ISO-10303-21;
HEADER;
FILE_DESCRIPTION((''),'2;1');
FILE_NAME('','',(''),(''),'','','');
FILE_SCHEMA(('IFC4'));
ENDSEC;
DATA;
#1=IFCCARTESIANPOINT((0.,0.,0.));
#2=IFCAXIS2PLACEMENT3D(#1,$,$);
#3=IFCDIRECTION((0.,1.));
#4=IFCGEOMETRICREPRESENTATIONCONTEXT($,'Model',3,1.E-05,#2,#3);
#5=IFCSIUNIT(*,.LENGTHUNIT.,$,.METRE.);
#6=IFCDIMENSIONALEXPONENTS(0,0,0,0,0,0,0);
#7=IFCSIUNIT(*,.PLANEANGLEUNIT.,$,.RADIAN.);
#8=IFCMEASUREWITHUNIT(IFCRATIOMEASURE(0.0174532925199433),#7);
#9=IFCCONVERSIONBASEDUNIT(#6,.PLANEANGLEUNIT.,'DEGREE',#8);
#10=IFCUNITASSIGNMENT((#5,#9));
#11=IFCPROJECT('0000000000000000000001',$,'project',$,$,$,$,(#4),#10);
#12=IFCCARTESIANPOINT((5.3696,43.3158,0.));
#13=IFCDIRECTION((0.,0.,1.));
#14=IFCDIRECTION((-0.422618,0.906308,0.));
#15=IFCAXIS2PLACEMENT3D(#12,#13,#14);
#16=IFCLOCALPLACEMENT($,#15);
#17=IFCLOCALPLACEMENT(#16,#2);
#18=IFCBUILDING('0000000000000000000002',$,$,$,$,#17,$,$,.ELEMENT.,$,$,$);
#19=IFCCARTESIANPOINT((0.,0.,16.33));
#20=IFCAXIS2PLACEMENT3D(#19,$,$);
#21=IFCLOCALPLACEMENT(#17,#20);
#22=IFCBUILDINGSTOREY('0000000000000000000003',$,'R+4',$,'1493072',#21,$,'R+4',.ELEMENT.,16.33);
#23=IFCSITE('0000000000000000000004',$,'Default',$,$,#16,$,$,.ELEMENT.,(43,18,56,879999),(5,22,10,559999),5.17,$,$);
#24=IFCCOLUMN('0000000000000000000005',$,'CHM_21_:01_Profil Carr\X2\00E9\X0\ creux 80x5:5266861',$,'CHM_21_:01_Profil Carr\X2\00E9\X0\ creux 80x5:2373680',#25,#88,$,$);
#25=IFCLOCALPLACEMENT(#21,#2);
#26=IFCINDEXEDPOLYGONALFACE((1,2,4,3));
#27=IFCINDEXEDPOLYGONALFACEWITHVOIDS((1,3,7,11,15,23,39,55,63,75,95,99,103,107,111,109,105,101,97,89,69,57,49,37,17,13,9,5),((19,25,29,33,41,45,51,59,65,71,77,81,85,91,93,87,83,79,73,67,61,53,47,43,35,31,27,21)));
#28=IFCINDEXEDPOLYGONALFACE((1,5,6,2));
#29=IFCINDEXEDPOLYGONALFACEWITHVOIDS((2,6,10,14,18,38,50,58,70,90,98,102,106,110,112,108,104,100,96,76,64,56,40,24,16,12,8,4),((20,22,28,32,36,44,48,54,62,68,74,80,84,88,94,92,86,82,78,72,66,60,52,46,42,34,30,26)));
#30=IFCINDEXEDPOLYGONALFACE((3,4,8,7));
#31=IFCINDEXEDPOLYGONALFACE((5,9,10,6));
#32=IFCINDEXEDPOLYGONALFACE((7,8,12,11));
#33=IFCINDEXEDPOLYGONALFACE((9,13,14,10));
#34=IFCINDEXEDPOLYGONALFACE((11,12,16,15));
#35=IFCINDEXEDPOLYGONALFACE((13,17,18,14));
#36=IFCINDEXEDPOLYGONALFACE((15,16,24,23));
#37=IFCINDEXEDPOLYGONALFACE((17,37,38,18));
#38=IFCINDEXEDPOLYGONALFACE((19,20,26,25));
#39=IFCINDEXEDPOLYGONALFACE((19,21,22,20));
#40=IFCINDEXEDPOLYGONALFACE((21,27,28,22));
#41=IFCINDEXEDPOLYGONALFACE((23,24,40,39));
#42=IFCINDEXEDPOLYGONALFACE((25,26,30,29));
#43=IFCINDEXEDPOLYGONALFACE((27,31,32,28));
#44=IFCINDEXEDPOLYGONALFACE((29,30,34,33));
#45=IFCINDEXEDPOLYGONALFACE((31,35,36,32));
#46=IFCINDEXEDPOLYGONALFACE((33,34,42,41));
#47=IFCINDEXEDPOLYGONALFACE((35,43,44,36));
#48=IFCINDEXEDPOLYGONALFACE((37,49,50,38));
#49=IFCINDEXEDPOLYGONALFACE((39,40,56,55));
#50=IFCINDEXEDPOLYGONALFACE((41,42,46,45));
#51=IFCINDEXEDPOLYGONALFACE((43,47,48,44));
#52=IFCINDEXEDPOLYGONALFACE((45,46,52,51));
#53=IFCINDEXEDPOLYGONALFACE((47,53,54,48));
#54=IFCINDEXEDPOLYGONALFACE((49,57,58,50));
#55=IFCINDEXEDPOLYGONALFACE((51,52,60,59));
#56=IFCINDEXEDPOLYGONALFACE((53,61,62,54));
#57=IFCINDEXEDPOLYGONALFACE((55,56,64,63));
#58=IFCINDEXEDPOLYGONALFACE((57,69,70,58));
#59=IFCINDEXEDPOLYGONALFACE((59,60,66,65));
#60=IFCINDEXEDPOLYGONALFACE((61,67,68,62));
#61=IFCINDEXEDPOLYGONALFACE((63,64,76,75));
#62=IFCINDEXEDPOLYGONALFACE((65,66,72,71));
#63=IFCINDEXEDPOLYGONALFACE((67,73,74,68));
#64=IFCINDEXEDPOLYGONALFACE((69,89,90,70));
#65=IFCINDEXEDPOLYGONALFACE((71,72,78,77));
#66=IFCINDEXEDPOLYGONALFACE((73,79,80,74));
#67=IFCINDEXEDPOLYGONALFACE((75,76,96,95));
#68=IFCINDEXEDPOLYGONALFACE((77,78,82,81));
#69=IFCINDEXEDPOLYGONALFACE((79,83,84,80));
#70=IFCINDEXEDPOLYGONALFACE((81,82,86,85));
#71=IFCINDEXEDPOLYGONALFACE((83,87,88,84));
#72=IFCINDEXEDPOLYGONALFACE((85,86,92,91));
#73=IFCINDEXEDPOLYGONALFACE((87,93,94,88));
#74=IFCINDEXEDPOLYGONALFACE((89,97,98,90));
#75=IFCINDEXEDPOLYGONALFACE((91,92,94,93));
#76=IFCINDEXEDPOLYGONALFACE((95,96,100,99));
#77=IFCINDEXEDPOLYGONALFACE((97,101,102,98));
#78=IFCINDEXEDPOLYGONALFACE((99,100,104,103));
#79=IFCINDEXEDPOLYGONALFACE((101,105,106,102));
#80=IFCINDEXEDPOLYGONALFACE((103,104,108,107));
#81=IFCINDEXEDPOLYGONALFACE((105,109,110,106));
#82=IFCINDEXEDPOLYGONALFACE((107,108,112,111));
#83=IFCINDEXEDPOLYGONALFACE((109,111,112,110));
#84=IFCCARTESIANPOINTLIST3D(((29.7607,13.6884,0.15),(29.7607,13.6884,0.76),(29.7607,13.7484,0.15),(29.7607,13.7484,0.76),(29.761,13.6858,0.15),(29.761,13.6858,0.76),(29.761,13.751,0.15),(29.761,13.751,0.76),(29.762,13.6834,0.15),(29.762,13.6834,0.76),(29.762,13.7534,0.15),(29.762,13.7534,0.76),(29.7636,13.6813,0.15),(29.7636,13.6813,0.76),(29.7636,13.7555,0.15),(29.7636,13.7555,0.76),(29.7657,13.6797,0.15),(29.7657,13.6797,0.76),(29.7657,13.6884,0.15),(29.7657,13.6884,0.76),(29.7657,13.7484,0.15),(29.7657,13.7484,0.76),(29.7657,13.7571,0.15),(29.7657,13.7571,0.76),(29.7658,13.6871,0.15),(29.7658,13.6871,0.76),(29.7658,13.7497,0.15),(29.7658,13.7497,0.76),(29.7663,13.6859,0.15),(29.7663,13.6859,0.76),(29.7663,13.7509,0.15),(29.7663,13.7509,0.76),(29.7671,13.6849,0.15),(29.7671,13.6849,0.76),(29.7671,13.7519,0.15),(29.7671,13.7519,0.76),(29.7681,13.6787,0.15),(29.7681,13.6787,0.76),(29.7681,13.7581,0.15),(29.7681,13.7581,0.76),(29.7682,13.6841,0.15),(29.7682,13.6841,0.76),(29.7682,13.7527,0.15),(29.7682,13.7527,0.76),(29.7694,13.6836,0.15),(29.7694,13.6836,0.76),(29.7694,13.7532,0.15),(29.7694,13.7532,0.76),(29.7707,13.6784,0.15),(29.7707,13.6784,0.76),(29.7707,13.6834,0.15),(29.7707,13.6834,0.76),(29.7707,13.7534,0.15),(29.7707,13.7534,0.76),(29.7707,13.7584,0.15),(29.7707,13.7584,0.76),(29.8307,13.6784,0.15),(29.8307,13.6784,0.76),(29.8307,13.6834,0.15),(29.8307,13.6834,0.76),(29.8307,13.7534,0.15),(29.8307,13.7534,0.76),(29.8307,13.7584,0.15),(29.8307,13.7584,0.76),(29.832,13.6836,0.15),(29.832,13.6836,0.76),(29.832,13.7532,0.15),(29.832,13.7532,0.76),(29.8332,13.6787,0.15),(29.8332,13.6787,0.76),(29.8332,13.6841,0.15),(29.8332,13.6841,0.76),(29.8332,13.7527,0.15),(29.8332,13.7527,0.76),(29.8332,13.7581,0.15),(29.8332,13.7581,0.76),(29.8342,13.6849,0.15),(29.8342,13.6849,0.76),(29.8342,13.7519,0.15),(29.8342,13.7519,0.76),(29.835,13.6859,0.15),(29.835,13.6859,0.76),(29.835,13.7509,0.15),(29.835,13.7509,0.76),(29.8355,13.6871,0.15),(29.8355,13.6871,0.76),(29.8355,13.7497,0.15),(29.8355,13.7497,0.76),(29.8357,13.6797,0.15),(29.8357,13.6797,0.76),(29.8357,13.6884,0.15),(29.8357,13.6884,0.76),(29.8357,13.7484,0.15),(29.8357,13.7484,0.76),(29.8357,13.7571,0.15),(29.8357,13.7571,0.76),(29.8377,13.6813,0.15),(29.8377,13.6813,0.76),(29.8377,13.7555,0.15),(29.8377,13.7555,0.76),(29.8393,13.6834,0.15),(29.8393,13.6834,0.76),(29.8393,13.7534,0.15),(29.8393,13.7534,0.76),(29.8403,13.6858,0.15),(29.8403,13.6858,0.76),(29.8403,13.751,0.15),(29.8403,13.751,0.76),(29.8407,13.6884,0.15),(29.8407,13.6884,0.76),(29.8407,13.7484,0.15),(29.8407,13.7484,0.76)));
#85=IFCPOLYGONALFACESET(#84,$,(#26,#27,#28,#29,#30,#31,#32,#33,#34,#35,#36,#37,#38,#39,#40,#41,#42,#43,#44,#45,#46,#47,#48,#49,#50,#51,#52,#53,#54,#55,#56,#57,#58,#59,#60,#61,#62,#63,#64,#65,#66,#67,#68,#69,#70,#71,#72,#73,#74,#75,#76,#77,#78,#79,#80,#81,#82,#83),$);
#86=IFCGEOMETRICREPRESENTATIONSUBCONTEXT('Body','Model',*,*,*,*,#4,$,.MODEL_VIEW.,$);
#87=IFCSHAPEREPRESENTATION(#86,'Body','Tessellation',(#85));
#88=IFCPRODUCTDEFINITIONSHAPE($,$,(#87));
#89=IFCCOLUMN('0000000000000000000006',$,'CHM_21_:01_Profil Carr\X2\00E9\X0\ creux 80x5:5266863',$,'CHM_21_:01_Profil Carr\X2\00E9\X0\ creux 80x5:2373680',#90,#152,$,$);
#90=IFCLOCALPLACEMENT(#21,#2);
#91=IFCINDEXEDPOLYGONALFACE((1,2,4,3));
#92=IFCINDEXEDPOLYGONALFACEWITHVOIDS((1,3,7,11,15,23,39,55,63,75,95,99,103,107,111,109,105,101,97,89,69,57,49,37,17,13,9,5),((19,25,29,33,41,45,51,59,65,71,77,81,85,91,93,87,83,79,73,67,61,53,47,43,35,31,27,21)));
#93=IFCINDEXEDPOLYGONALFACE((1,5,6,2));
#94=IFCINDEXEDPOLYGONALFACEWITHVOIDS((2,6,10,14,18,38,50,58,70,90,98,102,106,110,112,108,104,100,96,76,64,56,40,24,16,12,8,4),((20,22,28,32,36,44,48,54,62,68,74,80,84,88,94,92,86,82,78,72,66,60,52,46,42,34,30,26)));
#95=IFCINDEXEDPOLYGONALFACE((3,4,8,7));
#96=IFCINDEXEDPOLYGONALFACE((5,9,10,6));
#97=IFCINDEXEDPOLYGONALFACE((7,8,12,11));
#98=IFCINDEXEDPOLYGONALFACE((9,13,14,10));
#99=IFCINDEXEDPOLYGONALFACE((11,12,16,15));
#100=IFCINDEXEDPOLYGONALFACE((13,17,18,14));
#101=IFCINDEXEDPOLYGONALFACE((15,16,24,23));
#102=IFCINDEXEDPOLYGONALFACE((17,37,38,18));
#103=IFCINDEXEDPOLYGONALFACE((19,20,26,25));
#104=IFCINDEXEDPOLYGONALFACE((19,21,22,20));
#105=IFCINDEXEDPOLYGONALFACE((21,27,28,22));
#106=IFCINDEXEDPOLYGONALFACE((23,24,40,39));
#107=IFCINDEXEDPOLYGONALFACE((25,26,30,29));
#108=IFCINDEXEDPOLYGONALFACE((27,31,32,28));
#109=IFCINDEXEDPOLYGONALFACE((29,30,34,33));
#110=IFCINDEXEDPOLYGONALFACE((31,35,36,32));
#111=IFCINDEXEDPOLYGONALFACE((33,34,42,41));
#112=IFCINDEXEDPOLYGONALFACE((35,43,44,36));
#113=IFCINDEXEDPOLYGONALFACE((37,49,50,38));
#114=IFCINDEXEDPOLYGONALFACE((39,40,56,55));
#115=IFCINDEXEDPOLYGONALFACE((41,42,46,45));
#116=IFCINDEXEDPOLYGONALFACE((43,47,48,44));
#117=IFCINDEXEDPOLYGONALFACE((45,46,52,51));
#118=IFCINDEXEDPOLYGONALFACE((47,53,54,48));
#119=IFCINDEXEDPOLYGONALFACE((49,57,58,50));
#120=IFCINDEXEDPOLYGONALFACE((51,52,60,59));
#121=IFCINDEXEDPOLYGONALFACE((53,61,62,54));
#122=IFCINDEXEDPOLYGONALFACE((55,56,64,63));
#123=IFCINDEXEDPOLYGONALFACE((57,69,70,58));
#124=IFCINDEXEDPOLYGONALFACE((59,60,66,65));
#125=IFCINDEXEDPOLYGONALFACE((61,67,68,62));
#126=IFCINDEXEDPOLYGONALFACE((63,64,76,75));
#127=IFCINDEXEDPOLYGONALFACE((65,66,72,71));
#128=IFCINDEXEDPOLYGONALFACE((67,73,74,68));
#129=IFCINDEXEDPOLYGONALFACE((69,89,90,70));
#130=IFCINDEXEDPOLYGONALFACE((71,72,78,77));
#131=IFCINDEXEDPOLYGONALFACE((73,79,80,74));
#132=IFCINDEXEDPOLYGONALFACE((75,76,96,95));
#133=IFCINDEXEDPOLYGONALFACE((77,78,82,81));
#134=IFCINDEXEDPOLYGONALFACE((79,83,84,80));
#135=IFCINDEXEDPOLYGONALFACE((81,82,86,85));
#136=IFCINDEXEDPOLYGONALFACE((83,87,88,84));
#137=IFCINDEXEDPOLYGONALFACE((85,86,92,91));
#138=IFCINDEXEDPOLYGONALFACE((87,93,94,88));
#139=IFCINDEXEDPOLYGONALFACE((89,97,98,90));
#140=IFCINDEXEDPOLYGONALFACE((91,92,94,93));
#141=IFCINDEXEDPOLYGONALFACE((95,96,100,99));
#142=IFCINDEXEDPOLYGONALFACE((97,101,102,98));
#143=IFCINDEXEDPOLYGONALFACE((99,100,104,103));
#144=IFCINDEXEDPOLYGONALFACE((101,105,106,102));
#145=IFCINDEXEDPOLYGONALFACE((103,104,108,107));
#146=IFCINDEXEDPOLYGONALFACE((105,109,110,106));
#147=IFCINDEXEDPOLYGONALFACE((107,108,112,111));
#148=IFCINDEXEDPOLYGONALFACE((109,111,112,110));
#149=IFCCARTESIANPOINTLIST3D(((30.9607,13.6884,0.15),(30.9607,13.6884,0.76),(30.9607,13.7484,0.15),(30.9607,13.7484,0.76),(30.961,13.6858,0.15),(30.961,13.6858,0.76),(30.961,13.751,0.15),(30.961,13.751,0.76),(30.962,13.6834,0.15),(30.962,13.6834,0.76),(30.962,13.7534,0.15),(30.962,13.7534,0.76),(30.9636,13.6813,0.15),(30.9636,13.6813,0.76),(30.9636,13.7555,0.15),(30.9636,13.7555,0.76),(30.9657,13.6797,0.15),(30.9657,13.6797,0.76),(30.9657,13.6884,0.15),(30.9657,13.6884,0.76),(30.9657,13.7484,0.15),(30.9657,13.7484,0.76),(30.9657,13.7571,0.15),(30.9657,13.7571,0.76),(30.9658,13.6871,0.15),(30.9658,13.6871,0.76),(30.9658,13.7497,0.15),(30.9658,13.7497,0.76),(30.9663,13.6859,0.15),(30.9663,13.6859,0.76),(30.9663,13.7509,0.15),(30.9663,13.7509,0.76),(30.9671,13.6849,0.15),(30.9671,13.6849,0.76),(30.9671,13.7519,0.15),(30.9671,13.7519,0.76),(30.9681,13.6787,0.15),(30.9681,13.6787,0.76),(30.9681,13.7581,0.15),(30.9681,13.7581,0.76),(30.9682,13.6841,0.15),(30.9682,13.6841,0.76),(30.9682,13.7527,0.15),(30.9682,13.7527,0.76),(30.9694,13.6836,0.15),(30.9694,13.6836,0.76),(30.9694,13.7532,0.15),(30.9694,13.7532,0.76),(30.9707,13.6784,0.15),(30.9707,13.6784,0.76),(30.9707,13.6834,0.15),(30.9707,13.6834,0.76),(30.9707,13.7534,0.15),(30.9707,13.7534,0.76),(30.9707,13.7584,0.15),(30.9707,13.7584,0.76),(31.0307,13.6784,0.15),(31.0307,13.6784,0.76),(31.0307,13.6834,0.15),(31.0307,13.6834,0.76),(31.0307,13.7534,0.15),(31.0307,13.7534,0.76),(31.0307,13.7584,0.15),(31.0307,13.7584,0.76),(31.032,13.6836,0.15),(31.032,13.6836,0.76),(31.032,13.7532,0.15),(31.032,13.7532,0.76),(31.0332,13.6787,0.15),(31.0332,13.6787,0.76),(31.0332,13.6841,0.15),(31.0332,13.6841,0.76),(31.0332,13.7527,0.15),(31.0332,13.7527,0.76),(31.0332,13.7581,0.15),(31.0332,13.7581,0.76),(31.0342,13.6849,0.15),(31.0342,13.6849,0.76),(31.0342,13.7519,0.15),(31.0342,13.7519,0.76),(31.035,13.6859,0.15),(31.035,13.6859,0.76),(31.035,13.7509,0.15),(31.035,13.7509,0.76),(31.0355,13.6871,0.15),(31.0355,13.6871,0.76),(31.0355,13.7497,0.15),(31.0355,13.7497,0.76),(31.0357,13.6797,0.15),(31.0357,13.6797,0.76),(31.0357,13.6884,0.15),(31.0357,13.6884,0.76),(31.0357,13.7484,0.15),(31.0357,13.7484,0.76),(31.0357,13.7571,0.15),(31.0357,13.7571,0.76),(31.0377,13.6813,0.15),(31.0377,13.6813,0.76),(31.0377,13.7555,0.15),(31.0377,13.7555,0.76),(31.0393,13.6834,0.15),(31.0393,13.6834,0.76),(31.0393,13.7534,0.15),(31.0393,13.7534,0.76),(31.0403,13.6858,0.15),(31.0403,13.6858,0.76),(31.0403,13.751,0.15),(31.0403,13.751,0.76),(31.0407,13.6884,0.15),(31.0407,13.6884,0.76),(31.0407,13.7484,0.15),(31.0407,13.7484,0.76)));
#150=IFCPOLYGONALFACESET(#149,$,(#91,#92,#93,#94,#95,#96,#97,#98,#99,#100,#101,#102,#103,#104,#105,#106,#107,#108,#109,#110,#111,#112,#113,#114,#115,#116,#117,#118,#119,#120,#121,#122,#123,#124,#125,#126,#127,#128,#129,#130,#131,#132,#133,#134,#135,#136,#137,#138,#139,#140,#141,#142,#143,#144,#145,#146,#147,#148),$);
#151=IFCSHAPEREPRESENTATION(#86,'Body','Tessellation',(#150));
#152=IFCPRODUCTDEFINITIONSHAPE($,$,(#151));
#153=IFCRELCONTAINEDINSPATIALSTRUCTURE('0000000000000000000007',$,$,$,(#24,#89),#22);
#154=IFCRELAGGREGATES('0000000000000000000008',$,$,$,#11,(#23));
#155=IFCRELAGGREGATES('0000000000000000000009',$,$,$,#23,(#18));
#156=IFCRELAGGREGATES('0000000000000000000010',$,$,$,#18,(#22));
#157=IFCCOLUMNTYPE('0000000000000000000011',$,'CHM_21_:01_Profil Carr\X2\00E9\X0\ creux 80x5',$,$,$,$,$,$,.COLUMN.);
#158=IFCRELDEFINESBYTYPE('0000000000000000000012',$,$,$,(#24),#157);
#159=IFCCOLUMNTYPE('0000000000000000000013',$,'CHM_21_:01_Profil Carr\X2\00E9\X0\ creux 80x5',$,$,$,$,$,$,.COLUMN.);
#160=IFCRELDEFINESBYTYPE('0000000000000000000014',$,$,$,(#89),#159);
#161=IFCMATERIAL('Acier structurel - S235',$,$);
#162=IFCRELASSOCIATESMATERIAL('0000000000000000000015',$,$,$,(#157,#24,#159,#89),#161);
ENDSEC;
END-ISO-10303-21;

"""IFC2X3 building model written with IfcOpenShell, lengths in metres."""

from ifc_helpers import new_model, entity, si_unit, converted_unit, direction, frame, frame_2d, origin, place, context, subcontext, project, spatial, polyline, circle_curve, parameter, trimmed, segment, composite_curve, outline, extrude, source, transform, mapped, material, type_object, type_shapes, element, save


model = new_model("IFC2X3")

# Units and contexts
model_context = context("Model", 3, precision=1e-05, world=origin(), true_north=direction((0.0, 1.0)))
body_context = subcontext(model_context, "Body", "Model", "MODEL_VIEW")
ifc_project = project(units=[si_unit("LENGTHUNIT", "METRE"), converted_unit("PLANEANGLEUNIT", "DEGREE", entity("IfcRatioMeasure", 0.0174532925199433), si_unit("PLANEANGLEUNIT", "RADIAN"), dimensions=[0, 0, 0, 0, 0, 0, 0])], contexts=[model_context])

# Site, building, storey
site_placement = place(None, frame((5.3696, 43.3158, 0.0), z_axis=(0.0, 0.0, 1.0), x_axis=(-0.422618, 0.906308, 0.0)))
site = spatial("IfcSite", under=ifc_project, at=site_placement, Name="Default", CompositionType="ELEMENT", RefLatitude=(43, 18, 56, 879999), RefLongitude=(5, 22, 10, 559999), RefElevation=5.17)
building_placement = place(site_placement, origin())
building = spatial("IfcBuilding", under=site, at=building_placement, CompositionType="ELEMENT")
storey_placement = place(building_placement, frame((0.0, 0.0, 16.33)))
storey = spatial("IfcBuildingStorey", under=building, at=storey_placement, Name="R+4", ObjectType="1493072", LongName="R+4", CompositionType="ELEMENT", Elevation=16.33)

# Columns
ifc_material_1 = material(Name="Acier structurel - S235")
column_type_1 = type_object("IfcColumnType", Name="CHM_21_:01_Profil Carré creux 80x5", PredefinedType="COLUMN", material=ifc_material_1)
shared_shape_1 = source(origin(), body_context, "Body", "SweptSolid", [
    extrude(outline(composite_curve([segment(polyline([(-0.03, -0.04), (0.03, -0.04)]), True, "CONTINUOUS"), segment(trimmed(circle_curve(frame_2d((0.03, -0.03), x_axis=(-1.0, 0.0)), 0.01), [parameter(90.0)], [parameter(180.0)], True, "PARAMETER"), True, "CONTINUOUS"), segment(polyline([(0.04, -0.03), (0.04, 0.03)]), True, "CONTINUOUS"), segment(trimmed(circle_curve(frame_2d((0.03, 0.03), x_axis=(-1.0, 0.0)), 0.01), [parameter(180.0)], [parameter(270.0)], True, "PARAMETER"), True, "CONTINUOUS"), segment(polyline([(0.03, 0.04), (-0.03, 0.04)]), True, "CONTINUOUS"), segment(trimmed(circle_curve(frame_2d((-0.03, 0.03), x_axis=(-1.0, 0.0)), 0.01), [parameter(270.0)], [parameter(360.0)], True, "PARAMETER"), True, "CONTINUOUS"), segment(polyline([(-0.04, 0.03), (-0.04, -0.03)]), True, "CONTINUOUS"), segment(trimmed(circle_curve(frame_2d((-0.03, -0.03), x_axis=(-1.0, 0.0)), 0.01), [parameter(360.0)], [parameter(90.0)], True, "PARAMETER"), True, "CONTINUOUS")], self_intersect=False), holes=[composite_curve([segment(trimmed(circle_curve(frame_2d((-0.03, -0.03), x_axis=(-1.0, 0.0)), 0.005), [parameter(360.0)], [parameter(90.0)], True, "PARAMETER"), False, "CONTINUOUS"), segment(polyline([(-0.035, -0.03), (-0.035, 0.03)]), True, "CONTINUOUS"), segment(trimmed(circle_curve(frame_2d((-0.03, 0.03), x_axis=(-1.0, 0.0)), 0.005), [parameter(270.0)], [parameter(360.0)], True, "PARAMETER"), False, "CONTINUOUS"), segment(polyline([(-0.03, 0.035), (0.03, 0.035)]), True, "CONTINUOUS"), segment(trimmed(circle_curve(frame_2d((0.03, 0.03), x_axis=(-1.0, 0.0)), 0.005), [parameter(180.0)], [parameter(270.0)], True, "PARAMETER"), False, "CONTINUOUS"), segment(polyline([(0.035, 0.03), (0.035, -0.03)]), True, "CONTINUOUS"), segment(trimmed(circle_curve(frame_2d((0.03, -0.03), x_axis=(-1.0, 0.0)), 0.005), [parameter(90.0)], [parameter(180.0)], True, "PARAMETER"), False, "CONTINUOUS"), segment(polyline([(0.03, -0.035), (-0.03, -0.035)]), True, "CONTINUOUS")], self_intersect=False)]), frame((29.8007, 13.7184, 16.48), z_axis=(0.0, 0.0, 1.0), x_axis=(0.0, 1.0, 0.0)), (0.0, 0.0, 1.0), 0.61),
])
type_shapes(column_type_1, [shared_shape_1])
column_1_placement = place(storey_placement, frame((0.0, 0.0, -16.33)))
element("IfcColumn", 1, at=column_1_placement, inside=storey, type_object=column_type_1, material=ifc_material_1, Name="CHM_21_:01_Profil Carré creux 80x5:5266861", ObjectType="CHM_21_:01_Profil Carré creux 80x5:2373680", context=body_context, shape_type="MappedRepresentation", body=[
    mapped(shared_shape_1, transform((0.0, 0.0, 0.0), scale=1.0)),
])
column_type_2 = type_object("IfcColumnType", Name="CHM_21_:01_Profil Carré creux 80x5", PredefinedType="COLUMN", material=ifc_material_1)
shared_shape_2 = source(origin(), body_context, "Body", "SweptSolid", [
    extrude(outline(composite_curve([segment(polyline([(-0.03, -0.04), (0.03, -0.04)]), True, "CONTINUOUS"), segment(trimmed(circle_curve(frame_2d((0.03, -0.03), x_axis=(-1.0, 0.0)), 0.01), [parameter(90.0)], [parameter(180.0)], True, "PARAMETER"), True, "CONTINUOUS"), segment(polyline([(0.04, -0.03), (0.04, 0.03)]), True, "CONTINUOUS"), segment(trimmed(circle_curve(frame_2d((0.03, 0.03), x_axis=(-1.0, 0.0)), 0.01), [parameter(180.0)], [parameter(270.0)], True, "PARAMETER"), True, "CONTINUOUS"), segment(polyline([(0.03, 0.04), (-0.03, 0.04)]), True, "CONTINUOUS"), segment(trimmed(circle_curve(frame_2d((-0.03, 0.03), x_axis=(-1.0, 0.0)), 0.01), [parameter(270.0)], [parameter(360.0)], True, "PARAMETER"), True, "CONTINUOUS"), segment(polyline([(-0.04, 0.03), (-0.04, -0.03)]), True, "CONTINUOUS"), segment(trimmed(circle_curve(frame_2d((-0.03, -0.03), x_axis=(-1.0, 0.0)), 0.01), [parameter(360.0)], [parameter(90.0)], True, "PARAMETER"), True, "CONTINUOUS")], self_intersect=False), holes=[composite_curve([segment(trimmed(circle_curve(frame_2d((-0.03, -0.03), x_axis=(-1.0, 0.0)), 0.005), [parameter(360.0)], [parameter(90.0)], True, "PARAMETER"), False, "CONTINUOUS"), segment(polyline([(-0.035, -0.03), (-0.035, 0.03)]), True, "CONTINUOUS"), segment(trimmed(circle_curve(frame_2d((-0.03, 0.03), x_axis=(-1.0, 0.0)), 0.005), [parameter(270.0)], [parameter(360.0)], True, "PARAMETER"), False, "CONTINUOUS"), segment(polyline([(-0.03, 0.035), (0.03, 0.035)]), True, "CONTINUOUS"), segment(trimmed(circle_curve(frame_2d((0.03, 0.03), x_axis=(-1.0, 0.0)), 0.005), [parameter(180.0)], [parameter(270.0)], True, "PARAMETER"), False, "CONTINUOUS"), segment(polyline([(0.035, 0.03), (0.035, -0.03)]), True, "CONTINUOUS"), segment(trimmed(circle_curve(frame_2d((0.03, -0.03), x_axis=(-1.0, 0.0)), 0.005), [parameter(90.0)], [parameter(180.0)], True, "PARAMETER"), False, "CONTINUOUS"), segment(polyline([(0.03, -0.035), (-0.03, -0.035)]), True, "CONTINUOUS")], self_intersect=False)]), frame((31.0007, 13.7184, 16.48), z_axis=(0.0, 0.0, 1.0), x_axis=(0.0, 1.0, 0.0)), (0.0, 0.0, 1.0), 0.61),
])
type_shapes(column_type_2, [shared_shape_2])
column_2_placement = place(storey_placement, frame((0.0, 0.0, -16.33)))
element("IfcColumn", 2, at=column_2_placement, inside=storey, type_object=column_type_2, material=ifc_material_1, Name="CHM_21_:01_Profil Carré creux 80x5:5266863", ObjectType="CHM_21_:01_Profil Carré creux 80x5:2373680", context=body_context, shape_type="MappedRepresentation", body=[
    mapped(shared_shape_2, transform((0.0, 0.0, 0.0), scale=1.0)),
])

save(model, "model.ifc")
